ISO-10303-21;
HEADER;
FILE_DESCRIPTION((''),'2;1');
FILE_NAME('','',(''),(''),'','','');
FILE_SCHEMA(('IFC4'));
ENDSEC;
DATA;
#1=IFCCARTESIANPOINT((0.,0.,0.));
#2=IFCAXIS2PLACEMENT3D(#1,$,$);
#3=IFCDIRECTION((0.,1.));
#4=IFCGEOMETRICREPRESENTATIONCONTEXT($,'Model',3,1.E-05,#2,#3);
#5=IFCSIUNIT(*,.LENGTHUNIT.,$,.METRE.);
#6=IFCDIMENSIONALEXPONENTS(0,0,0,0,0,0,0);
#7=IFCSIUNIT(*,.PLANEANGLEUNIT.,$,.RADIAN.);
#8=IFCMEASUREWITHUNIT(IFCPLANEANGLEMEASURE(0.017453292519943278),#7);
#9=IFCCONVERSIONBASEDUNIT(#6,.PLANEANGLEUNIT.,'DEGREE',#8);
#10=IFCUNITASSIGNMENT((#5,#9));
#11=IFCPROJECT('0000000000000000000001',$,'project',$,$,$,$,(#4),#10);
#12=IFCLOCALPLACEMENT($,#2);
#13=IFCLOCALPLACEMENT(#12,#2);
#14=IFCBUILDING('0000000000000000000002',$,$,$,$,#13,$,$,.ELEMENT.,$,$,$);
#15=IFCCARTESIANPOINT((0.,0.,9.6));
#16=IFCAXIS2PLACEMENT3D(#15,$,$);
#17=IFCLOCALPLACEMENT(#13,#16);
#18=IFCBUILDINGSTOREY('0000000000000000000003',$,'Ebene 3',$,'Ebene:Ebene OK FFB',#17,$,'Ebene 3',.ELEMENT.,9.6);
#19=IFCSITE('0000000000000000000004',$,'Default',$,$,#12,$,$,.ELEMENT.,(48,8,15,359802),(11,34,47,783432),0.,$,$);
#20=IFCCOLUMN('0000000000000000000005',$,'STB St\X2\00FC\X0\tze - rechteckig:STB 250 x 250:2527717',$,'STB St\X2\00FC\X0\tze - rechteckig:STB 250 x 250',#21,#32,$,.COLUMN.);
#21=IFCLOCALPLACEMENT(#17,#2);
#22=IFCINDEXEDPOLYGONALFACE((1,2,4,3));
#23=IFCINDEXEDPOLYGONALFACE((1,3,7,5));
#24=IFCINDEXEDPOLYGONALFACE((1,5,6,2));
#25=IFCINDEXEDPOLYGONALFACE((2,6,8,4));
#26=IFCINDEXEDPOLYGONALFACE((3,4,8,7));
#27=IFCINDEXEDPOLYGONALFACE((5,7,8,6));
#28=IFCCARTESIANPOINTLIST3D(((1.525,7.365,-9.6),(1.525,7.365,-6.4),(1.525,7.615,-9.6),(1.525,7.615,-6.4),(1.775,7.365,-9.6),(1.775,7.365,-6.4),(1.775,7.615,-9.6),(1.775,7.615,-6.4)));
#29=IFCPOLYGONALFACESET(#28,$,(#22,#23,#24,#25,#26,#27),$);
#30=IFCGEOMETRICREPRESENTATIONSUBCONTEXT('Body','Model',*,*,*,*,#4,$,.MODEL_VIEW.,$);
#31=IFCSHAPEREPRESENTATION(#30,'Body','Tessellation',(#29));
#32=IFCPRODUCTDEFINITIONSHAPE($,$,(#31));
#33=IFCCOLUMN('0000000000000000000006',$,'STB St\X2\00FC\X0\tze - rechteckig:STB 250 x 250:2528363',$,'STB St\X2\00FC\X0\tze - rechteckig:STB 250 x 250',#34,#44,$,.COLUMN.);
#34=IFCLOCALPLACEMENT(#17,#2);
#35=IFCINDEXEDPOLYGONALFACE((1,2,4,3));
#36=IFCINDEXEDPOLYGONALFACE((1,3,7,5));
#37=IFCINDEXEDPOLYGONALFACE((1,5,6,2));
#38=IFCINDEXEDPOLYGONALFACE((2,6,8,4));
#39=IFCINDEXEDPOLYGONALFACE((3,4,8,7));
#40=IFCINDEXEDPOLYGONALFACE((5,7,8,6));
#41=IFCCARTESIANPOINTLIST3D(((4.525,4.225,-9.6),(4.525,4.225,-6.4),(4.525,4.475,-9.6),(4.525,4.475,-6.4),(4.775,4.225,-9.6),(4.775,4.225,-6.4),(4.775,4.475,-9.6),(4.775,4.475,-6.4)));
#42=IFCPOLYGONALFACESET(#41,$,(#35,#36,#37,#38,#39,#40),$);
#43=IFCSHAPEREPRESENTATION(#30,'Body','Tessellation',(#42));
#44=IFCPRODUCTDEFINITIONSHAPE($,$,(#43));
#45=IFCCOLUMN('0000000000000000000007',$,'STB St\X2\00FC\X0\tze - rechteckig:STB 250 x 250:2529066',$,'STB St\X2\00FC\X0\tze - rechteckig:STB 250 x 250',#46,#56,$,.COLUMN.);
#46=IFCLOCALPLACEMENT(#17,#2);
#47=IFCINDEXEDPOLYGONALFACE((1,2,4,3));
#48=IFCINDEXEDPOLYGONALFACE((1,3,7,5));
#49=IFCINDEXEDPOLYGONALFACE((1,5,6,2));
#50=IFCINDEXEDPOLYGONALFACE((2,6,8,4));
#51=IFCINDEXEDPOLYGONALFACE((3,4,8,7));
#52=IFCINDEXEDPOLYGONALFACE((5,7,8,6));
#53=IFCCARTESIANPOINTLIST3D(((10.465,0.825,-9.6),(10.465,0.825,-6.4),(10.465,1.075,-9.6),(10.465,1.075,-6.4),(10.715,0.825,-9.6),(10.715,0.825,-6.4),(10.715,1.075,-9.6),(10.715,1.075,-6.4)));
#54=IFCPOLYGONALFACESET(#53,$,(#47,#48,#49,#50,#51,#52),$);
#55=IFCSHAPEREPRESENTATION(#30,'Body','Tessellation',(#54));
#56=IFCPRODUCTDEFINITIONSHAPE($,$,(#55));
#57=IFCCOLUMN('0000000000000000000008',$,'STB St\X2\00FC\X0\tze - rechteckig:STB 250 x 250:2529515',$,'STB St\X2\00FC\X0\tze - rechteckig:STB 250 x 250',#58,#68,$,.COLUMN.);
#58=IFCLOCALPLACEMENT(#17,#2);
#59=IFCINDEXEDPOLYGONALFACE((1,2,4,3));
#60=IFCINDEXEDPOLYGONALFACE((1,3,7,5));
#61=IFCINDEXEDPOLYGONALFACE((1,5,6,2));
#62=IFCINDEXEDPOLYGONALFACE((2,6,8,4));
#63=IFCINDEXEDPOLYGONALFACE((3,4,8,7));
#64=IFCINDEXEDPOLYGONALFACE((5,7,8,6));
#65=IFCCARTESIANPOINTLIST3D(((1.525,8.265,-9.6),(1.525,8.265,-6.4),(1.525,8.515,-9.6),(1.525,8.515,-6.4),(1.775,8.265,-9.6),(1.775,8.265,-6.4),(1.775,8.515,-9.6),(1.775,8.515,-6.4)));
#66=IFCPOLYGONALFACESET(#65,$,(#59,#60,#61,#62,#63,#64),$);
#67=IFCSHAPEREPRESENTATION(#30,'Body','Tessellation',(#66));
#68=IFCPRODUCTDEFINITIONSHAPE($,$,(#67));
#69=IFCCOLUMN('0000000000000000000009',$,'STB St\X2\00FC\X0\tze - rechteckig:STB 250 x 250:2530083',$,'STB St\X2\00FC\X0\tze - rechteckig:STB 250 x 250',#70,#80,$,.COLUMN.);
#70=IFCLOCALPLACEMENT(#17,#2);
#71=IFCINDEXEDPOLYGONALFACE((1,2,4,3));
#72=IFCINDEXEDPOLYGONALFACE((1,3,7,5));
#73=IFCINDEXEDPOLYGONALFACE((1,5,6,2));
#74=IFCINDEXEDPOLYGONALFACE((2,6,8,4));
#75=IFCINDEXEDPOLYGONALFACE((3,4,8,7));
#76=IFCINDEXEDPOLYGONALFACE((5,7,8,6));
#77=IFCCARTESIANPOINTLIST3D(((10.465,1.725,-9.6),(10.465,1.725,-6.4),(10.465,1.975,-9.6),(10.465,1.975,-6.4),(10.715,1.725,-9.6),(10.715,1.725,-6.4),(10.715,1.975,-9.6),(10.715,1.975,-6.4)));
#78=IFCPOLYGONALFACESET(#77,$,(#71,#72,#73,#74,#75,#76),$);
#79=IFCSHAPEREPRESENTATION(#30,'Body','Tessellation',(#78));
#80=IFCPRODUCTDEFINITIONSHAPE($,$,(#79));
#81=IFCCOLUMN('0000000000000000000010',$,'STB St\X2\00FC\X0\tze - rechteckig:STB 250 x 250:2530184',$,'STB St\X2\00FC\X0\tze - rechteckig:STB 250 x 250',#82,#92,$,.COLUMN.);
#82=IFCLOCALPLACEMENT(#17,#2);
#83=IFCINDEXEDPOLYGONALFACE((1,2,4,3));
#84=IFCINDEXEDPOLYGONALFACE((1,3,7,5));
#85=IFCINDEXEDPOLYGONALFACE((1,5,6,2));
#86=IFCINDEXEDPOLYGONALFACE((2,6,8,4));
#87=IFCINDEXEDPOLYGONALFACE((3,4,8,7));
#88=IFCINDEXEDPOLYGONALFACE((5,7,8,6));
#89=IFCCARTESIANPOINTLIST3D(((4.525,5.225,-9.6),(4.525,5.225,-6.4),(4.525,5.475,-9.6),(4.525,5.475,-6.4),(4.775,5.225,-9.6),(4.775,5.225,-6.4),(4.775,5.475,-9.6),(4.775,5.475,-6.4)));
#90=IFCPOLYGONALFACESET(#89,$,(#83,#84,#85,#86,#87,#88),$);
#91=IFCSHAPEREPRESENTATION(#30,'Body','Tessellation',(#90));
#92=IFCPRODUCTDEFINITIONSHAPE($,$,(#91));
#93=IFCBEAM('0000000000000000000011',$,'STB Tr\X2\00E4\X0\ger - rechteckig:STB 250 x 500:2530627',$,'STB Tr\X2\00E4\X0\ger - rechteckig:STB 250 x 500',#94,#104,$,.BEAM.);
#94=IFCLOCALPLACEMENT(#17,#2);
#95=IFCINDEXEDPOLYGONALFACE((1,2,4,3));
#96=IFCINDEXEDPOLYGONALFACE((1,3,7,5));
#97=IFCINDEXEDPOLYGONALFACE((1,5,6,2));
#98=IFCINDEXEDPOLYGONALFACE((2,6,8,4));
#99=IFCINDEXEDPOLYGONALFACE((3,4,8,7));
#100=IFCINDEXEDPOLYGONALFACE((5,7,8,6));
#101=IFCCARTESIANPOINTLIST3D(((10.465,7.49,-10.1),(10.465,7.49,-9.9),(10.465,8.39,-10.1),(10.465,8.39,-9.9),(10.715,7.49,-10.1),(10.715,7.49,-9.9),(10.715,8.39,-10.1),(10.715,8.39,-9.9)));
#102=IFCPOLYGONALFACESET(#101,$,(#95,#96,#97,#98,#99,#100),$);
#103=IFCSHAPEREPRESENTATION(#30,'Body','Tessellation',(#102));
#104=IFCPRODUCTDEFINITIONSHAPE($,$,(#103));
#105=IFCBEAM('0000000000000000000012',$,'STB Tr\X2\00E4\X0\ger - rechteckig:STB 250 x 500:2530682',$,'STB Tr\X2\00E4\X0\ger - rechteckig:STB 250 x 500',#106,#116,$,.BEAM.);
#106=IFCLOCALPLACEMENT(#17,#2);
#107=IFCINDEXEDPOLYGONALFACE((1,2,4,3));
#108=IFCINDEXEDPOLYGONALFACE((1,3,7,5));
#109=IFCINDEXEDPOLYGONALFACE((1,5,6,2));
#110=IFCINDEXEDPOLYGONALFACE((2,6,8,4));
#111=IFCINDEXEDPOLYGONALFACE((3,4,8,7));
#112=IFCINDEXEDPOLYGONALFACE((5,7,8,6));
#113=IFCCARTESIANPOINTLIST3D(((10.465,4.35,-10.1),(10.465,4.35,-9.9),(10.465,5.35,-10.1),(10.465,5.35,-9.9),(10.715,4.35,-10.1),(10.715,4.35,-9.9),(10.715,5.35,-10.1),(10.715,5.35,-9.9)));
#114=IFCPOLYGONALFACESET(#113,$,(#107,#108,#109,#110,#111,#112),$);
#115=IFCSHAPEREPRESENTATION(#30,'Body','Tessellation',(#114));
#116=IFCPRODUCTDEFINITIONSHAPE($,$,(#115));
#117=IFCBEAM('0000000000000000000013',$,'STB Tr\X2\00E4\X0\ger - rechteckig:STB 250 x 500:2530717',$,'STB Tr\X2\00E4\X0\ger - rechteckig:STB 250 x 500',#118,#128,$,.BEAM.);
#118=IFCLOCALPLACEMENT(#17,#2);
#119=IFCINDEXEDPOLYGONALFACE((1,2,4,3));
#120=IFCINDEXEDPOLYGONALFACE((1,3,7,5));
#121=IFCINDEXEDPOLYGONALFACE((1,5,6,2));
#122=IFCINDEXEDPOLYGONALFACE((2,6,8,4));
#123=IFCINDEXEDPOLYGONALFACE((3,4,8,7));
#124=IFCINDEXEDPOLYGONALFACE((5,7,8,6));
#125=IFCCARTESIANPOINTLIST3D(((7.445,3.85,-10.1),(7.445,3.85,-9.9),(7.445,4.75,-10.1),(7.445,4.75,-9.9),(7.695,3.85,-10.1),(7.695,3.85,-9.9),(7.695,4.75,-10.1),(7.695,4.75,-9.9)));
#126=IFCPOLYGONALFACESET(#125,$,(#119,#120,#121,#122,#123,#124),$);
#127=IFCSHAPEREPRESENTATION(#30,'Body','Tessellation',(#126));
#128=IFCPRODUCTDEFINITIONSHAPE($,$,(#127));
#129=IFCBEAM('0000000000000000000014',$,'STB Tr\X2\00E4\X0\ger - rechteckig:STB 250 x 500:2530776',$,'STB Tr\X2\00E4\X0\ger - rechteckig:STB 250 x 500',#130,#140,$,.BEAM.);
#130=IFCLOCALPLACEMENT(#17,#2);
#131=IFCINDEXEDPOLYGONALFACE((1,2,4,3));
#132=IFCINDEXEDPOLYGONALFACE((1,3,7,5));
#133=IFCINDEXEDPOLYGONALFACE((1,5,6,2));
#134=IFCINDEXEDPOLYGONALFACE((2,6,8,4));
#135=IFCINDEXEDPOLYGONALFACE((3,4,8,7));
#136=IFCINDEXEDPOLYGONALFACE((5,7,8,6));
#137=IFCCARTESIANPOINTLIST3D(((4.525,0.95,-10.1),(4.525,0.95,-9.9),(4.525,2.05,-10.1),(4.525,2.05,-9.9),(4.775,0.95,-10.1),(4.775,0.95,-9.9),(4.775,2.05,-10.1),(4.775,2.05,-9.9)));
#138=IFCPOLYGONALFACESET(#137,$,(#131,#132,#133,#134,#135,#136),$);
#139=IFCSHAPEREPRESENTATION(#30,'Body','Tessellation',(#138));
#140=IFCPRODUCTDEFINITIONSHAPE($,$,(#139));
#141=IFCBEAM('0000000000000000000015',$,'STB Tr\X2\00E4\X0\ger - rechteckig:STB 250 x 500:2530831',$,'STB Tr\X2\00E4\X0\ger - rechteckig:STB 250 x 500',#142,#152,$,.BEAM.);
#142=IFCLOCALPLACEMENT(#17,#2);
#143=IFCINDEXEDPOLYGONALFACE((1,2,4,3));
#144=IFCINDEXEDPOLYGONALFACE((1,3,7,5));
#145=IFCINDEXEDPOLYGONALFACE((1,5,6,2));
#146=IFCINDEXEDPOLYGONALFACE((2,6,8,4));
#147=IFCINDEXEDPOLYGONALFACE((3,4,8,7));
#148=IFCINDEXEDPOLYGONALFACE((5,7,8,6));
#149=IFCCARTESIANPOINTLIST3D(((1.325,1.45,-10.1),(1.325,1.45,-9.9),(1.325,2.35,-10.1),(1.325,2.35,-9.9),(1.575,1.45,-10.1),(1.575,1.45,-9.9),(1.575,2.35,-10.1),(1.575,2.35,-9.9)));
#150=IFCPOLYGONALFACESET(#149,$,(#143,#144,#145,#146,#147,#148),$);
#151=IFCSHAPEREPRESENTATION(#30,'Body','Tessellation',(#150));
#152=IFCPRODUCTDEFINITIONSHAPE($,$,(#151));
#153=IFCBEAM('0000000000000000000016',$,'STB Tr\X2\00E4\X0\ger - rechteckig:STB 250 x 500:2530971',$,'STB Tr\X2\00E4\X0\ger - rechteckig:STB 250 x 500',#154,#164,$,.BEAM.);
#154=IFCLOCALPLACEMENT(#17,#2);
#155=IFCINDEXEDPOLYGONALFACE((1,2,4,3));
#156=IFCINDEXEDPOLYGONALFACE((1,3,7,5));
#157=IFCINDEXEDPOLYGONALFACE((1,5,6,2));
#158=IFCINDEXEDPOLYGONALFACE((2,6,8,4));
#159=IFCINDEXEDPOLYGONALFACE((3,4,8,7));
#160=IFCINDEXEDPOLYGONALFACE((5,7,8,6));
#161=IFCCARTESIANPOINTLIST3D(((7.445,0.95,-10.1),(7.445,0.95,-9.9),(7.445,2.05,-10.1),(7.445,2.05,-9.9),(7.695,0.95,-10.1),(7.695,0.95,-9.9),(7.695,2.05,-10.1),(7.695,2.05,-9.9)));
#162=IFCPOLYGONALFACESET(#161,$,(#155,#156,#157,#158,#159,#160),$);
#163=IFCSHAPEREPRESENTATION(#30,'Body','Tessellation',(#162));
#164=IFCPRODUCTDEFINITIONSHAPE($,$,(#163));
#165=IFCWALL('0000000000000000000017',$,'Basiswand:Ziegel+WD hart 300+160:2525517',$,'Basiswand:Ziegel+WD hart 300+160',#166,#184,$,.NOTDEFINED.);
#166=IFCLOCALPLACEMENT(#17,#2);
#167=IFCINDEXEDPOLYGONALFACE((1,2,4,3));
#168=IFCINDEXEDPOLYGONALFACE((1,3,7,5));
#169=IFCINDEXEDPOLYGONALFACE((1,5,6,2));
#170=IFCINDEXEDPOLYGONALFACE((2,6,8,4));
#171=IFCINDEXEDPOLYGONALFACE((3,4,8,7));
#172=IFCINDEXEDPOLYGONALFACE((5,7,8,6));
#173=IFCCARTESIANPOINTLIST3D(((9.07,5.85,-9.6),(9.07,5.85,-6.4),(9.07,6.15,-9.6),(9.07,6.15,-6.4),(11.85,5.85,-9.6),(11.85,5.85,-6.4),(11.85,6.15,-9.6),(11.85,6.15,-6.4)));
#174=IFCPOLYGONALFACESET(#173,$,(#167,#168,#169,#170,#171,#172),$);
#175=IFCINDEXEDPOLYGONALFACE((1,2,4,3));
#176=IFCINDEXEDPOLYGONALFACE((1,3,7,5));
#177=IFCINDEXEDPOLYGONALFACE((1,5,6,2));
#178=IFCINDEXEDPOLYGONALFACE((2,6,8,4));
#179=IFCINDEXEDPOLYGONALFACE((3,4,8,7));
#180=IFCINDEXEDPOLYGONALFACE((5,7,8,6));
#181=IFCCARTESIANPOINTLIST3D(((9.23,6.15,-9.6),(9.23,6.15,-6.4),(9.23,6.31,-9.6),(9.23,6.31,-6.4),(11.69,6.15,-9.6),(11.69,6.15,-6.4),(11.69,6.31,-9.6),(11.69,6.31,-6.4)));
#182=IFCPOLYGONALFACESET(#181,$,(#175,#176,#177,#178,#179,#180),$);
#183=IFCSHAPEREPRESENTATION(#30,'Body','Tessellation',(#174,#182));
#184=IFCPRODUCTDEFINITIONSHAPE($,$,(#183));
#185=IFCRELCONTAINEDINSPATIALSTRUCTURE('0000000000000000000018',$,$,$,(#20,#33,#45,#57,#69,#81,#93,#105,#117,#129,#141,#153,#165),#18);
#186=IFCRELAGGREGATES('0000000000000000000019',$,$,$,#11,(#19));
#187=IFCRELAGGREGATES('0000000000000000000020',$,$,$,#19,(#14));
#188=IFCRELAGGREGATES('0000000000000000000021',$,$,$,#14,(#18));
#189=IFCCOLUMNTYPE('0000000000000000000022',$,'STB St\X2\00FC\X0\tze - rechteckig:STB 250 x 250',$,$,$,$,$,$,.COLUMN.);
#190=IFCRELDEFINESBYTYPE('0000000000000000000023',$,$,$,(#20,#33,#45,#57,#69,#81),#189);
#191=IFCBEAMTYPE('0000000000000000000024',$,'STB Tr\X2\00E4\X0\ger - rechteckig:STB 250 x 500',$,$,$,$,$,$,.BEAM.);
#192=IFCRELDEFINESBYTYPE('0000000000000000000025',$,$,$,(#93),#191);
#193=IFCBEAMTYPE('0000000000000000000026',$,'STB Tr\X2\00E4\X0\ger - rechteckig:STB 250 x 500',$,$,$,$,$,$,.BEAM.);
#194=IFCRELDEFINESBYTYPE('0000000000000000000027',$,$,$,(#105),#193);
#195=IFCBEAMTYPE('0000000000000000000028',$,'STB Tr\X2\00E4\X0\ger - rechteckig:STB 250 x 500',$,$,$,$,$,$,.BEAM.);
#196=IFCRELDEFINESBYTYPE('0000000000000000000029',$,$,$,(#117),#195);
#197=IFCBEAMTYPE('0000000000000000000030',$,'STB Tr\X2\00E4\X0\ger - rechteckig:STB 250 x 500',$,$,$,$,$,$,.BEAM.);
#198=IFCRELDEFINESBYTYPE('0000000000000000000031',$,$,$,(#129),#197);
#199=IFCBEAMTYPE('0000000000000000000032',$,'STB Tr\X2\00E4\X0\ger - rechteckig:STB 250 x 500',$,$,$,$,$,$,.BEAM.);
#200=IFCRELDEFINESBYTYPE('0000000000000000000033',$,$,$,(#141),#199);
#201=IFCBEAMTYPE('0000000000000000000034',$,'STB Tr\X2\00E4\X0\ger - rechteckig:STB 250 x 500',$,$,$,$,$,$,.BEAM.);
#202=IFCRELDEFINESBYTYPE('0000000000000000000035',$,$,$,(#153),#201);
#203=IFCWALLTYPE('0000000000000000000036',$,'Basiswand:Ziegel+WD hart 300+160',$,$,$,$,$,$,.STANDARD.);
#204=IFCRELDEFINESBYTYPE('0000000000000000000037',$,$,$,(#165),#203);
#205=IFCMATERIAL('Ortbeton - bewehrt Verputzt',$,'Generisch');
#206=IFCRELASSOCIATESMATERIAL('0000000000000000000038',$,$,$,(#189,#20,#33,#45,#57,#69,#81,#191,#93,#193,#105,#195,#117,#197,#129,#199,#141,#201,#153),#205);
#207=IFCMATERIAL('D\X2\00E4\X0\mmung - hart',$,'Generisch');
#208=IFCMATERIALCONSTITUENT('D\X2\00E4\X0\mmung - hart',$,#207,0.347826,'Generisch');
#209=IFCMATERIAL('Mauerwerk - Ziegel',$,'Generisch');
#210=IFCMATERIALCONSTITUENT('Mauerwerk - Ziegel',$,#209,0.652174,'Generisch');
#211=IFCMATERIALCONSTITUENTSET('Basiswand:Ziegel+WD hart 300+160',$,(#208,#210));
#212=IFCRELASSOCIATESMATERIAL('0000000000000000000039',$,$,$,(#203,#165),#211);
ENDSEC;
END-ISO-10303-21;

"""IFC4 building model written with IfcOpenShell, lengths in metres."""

from ifc_helpers import new_model, entity, si_unit, converted_unit, direction, frame, origin, place, context, subcontext, project, spatial, indexed_curve, outline, extrude, source, transform, mapped, material, constituent, constituent_set, type_object, type_shapes, element, save


model = new_model("IFC4")

# Units and contexts
model_context = context("Model", 3, precision=1e-05, world=origin(), true_north=direction((0.0, 1.0)))
body_context = subcontext(model_context, "Body", "Model", "MODEL_VIEW")
ifc_project = project(units=[si_unit("LENGTHUNIT", "METRE"), converted_unit("PLANEANGLEUNIT", "DEGREE", entity("IfcPlaneAngleMeasure", 0.017453292519943278), si_unit("PLANEANGLEUNIT", "RADIAN"), dimensions=[0, 0, 0, 0, 0, 0, 0])], contexts=[model_context])

# Site, building, storey
site_placement = place(None, origin())
site = spatial("IfcSite", under=ifc_project, at=site_placement, Name="Default", CompositionType="ELEMENT", RefLatitude=(48, 8, 15, 359802), RefLongitude=(11, 34, 47, 783432), RefElevation=0.0)
building_placement = place(site_placement, origin())
building = spatial("IfcBuilding", under=site, at=building_placement, CompositionType="ELEMENT")
storey_placement = place(building_placement, frame((0.0, 0.0, 9.6)))
storey = spatial("IfcBuildingStorey", under=building, at=storey_placement, Name="Ebene 3", ObjectType="Ebene:Ebene OK FFB", LongName="Ebene 3", CompositionType="ELEMENT", Elevation=9.6)

# Columns
ifc_material_1 = material(Name="Ortbeton - bewehrt Verputzt", Category="Generisch")
column_type = type_object("IfcColumnType", Name="STB Stütze - rechteckig:STB 250 x 250", PredefinedType="COLUMN", material=ifc_material_1)
shared_shape_1 = source(origin(), body_context, "Body", "SweptSolid", [
    extrude(outline(indexed_curve([(-0.125, -0.125), (0.125, -0.125), (0.125, 0.125), (-0.125, 0.125), (-0.125, -0.125)], self_intersect=False)), frame((0.0, 0.0, 0.0), z_axis=(0.0, 0.0, 1.0), x_axis=(-1.0, 0.0, 0.0)), (0.0, 0.0, 1.0), 3.2),
])
type_shapes(column_type, [shared_shape_1])
for number, where, name in (
    (1, (1.65, 7.49, -9.6), "STB Stütze - rechteckig:STB 250 x 250:2527717"),
    (2, (4.65, 4.35, -9.6), "STB Stütze - rechteckig:STB 250 x 250:2528363"),
    (3, (10.59, 0.95, -9.6), "STB Stütze - rechteckig:STB 250 x 250:2529066"),
    (4, (1.65, 8.39, -9.6), "STB Stütze - rechteckig:STB 250 x 250:2529515"),
    (5, (10.59, 1.85, -9.6), "STB Stütze - rechteckig:STB 250 x 250:2530083"),
    (6, (4.65, 5.35, -9.6), "STB Stütze - rechteckig:STB 250 x 250:2530184"),
):
    element("IfcColumn", number, at=place(storey_placement, frame(where)), inside=storey, type_object=column_type, material=ifc_material_1, Name=name, ObjectType="STB Stütze - rechteckig:STB 250 x 250", PredefinedType="COLUMN", context=body_context, shape_type="MappedRepresentation", body=[
        mapped(shared_shape_1, transform((0.0, 0.0, 0.0), scale=1.0)),
    ])

# Beams
beam_type_1 = type_object("IfcBeamType", Name="STB Träger - rechteckig:STB 250 x 500", PredefinedType="BEAM", material=ifc_material_1)
shared_shape_2 = source(origin(), body_context, "Body", "SweptSolid", [
    extrude(outline(indexed_curve([(-0.125, -0.1), (0.125, -0.1), (0.125, 0.1), (-0.125, 0.1), (-0.125, -0.1)], self_intersect=False)), frame((10.59, 8.39, -0.4), z_axis=(0.0, -1.0, 0.0), x_axis=(-1.0, 0.0, 0.0)), (0.0, 0.0, 1.0), 0.9),
])
type_shapes(beam_type_1, [shared_shape_2])
beam_1_placement = place(storey_placement, frame((0.0, 0.0, -9.6)))
element("IfcBeam", 7, at=beam_1_placement, inside=storey, type_object=beam_type_1, material=ifc_material_1, Name="STB Träger - rechteckig:STB 250 x 500:2530627", ObjectType="STB Träger - rechteckig:STB 250 x 500", PredefinedType="BEAM", context=body_context, shape_type="MappedRepresentation", body=[
    mapped(shared_shape_2, transform((0.0, 0.0, 0.0), scale=1.0)),
])
beam_type_2 = type_object("IfcBeamType", Name="STB Träger - rechteckig:STB 250 x 500", PredefinedType="BEAM", material=ifc_material_1)
shared_shape_3 = source(origin(), body_context, "Body", "SweptSolid", [
    extrude(outline(indexed_curve([(-0.125, -0.1), (0.125, -0.1), (0.125, 0.1), (-0.125, 0.1), (-0.125, -0.1)], self_intersect=False)), frame((10.59, 5.35, -0.4), z_axis=(0.0, -1.0, 0.0), x_axis=(-1.0, 0.0, 0.0)), (0.0, 0.0, 1.0), 1.0),
])
type_shapes(beam_type_2, [shared_shape_3])
beam_2_placement = place(storey_placement, frame((0.0, 0.0, -9.6)))
element("IfcBeam", 8, at=beam_2_placement, inside=storey, type_object=beam_type_2, material=ifc_material_1, Name="STB Träger - rechteckig:STB 250 x 500:2530682", ObjectType="STB Träger - rechteckig:STB 250 x 500", PredefinedType="BEAM", context=body_context, shape_type="MappedRepresentation", body=[
    mapped(shared_shape_3, transform((0.0, 0.0, 0.0), scale=1.0)),
])
beam_type_3 = type_object("IfcBeamType", Name="STB Träger - rechteckig:STB 250 x 500", PredefinedType="BEAM", material=ifc_material_1)
shared_shape_4 = source(origin(), body_context, "Body", "SweptSolid", [
    extrude(outline(indexed_curve([(-0.125, -0.1), (0.125, -0.1), (0.125, 0.1), (-0.125, 0.1), (-0.125, -0.1)], self_intersect=False)), frame((7.57, 4.75, -0.4), z_axis=(0.0, -1.0, 0.0), x_axis=(-1.0, 0.0, 0.0)), (0.0, 0.0, 1.0), 0.9),
])
type_shapes(beam_type_3, [shared_shape_4])
beam_3_placement = place(storey_placement, frame((0.0, 0.0, -9.6)))
element("IfcBeam", 9, at=beam_3_placement, inside=storey, type_object=beam_type_3, material=ifc_material_1, Name="STB Träger - rechteckig:STB 250 x 500:2530717", ObjectType="STB Träger - rechteckig:STB 250 x 500", PredefinedType="BEAM", context=body_context, shape_type="MappedRepresentation", body=[
    mapped(shared_shape_4, transform((0.0, 0.0, 0.0), scale=1.0)),
])
beam_type_4 = type_object("IfcBeamType", Name="STB Träger - rechteckig:STB 250 x 500", PredefinedType="BEAM", material=ifc_material_1)
shared_shape_5 = source(origin(), body_context, "Body", "SweptSolid", [
    extrude(outline(indexed_curve([(-0.125, -0.1), (0.125, -0.1), (0.125, 0.1), (-0.125, 0.1), (-0.125, -0.1)], self_intersect=False)), frame((4.65, 2.05, -0.4), z_axis=(0.0, -1.0, 0.0), x_axis=(-1.0, 0.0, 0.0)), (0.0, 0.0, 1.0), 1.1),
])
type_shapes(beam_type_4, [shared_shape_5])
beam_4_placement = place(storey_placement, frame((0.0, 0.0, -9.6)))
element("IfcBeam", 10, at=beam_4_placement, inside=storey, type_object=beam_type_4, material=ifc_material_1, Name="STB Träger - rechteckig:STB 250 x 500:2530776", ObjectType="STB Träger - rechteckig:STB 250 x 500", PredefinedType="BEAM", context=body_context, shape_type="MappedRepresentation", body=[
    mapped(shared_shape_5, transform((0.0, 0.0, 0.0), scale=1.0)),
])
beam_type_5 = type_object("IfcBeamType", Name="STB Träger - rechteckig:STB 250 x 500", PredefinedType="BEAM", material=ifc_material_1)
shared_shape_6 = source(origin(), body_context, "Body", "SweptSolid", [
    extrude(outline(indexed_curve([(-0.125, -0.1), (0.125, -0.1), (0.125, 0.1), (-0.125, 0.1), (-0.125, -0.1)], self_intersect=False)), frame((1.45, 2.35, -0.4), z_axis=(0.0, -1.0, 0.0), x_axis=(-1.0, 0.0, 0.0)), (0.0, 0.0, 1.0), 0.9),
])
type_shapes(beam_type_5, [shared_shape_6])
beam_5_placement = place(storey_placement, frame((0.0, 0.0, -9.6)))
element("IfcBeam", 11, at=beam_5_placement, inside=storey, type_object=beam_type_5, material=ifc_material_1, Name="STB Träger - rechteckig:STB 250 x 500:2530831", ObjectType="STB Träger - rechteckig:STB 250 x 500", PredefinedType="BEAM", context=body_context, shape_type="MappedRepresentation", body=[
    mapped(shared_shape_6, transform((0.0, 0.0, 0.0), scale=1.0)),
])
beam_type_6 = type_object("IfcBeamType", Name="STB Träger - rechteckig:STB 250 x 500", PredefinedType="BEAM", material=ifc_material_1)
shared_shape_7 = source(origin(), body_context, "Body", "SweptSolid", [
    extrude(outline(indexed_curve([(-0.125, -0.1), (0.125, -0.1), (0.125, 0.1), (-0.125, 0.1), (-0.125, -0.1)], self_intersect=False)), frame((7.57, 2.05, -0.4), z_axis=(0.0, -1.0, 0.0), x_axis=(-1.0, 0.0, 0.0)), (0.0, 0.0, 1.0), 1.1),
])
type_shapes(beam_type_6, [shared_shape_7])
beam_6_placement = place(storey_placement, frame((0.0, 0.0, -9.6)))
element("IfcBeam", 12, at=beam_6_placement, inside=storey, type_object=beam_type_6, material=ifc_material_1, Name="STB Träger - rechteckig:STB 250 x 500:2530971", ObjectType="STB Träger - rechteckig:STB 250 x 500", PredefinedType="BEAM", context=body_context, shape_type="MappedRepresentation", body=[
    mapped(shared_shape_7, transform((0.0, 0.0, 0.0), scale=1.0)),
])

# Shared definitions
ifc_material_2 = material(Name="Dämmung - hart", Category="Generisch")
ifc_constituent_1 = constituent(ifc_material_2, Name="Dämmung - hart", Category="Generisch", fraction=0.347826)
ifc_material_3 = material(Name="Mauerwerk - Ziegel", Category="Generisch")
ifc_constituent_2 = constituent(ifc_material_3, Name="Mauerwerk - Ziegel", Category="Generisch", fraction=0.652174)
ifc_constituent_set = constituent_set(constituents=[ifc_constituent_1, ifc_constituent_2], Name="Basiswand:Ziegel+WD hart 300+160")
wall_type = type_object("IfcWallType", Name="Basiswand:Ziegel+WD hart 300+160", PredefinedType="STANDARD", material=ifc_constituent_set)

# Wall
wall_1_placement = place(storey_placement, frame((9.23, 6.08, -9.6)))
element("IfcWall", 13, at=wall_1_placement, inside=storey, type_object=wall_type, material=ifc_constituent_set, Name="Basiswand:Ziegel+WD hart 300+160:2525517", ObjectType="Basiswand:Ziegel+WD hart 300+160", PredefinedType="NOTDEFINED", context=body_context, shape_type="SweptSolid", body=[
    extrude(outline(indexed_curve([(-0.15, -1.39), (0.15, -1.39), (0.15, 1.39), (-0.15, 1.39), (-0.15, -1.39)], self_intersect=False)), frame((1.23, -0.08, 0.0), z_axis=(0.0, 0.0, 1.0), x_axis=(0.0, 1.0, 0.0)), (0.0, 0.0, 1.0), 3.2),
    extrude(outline(indexed_curve([(-0.08, -1.23), (0.08, -1.23), (0.08, 1.23), (-0.08, 1.23), (-0.08, -1.23)], self_intersect=False)), frame((1.23, 0.15, 0.0), z_axis=(0.0, 0.0, 1.0), x_axis=(0.0, -1.0, 0.0)), (0.0, 0.0, 1.0), 3.2),
])

save(model, "model.ifc")
